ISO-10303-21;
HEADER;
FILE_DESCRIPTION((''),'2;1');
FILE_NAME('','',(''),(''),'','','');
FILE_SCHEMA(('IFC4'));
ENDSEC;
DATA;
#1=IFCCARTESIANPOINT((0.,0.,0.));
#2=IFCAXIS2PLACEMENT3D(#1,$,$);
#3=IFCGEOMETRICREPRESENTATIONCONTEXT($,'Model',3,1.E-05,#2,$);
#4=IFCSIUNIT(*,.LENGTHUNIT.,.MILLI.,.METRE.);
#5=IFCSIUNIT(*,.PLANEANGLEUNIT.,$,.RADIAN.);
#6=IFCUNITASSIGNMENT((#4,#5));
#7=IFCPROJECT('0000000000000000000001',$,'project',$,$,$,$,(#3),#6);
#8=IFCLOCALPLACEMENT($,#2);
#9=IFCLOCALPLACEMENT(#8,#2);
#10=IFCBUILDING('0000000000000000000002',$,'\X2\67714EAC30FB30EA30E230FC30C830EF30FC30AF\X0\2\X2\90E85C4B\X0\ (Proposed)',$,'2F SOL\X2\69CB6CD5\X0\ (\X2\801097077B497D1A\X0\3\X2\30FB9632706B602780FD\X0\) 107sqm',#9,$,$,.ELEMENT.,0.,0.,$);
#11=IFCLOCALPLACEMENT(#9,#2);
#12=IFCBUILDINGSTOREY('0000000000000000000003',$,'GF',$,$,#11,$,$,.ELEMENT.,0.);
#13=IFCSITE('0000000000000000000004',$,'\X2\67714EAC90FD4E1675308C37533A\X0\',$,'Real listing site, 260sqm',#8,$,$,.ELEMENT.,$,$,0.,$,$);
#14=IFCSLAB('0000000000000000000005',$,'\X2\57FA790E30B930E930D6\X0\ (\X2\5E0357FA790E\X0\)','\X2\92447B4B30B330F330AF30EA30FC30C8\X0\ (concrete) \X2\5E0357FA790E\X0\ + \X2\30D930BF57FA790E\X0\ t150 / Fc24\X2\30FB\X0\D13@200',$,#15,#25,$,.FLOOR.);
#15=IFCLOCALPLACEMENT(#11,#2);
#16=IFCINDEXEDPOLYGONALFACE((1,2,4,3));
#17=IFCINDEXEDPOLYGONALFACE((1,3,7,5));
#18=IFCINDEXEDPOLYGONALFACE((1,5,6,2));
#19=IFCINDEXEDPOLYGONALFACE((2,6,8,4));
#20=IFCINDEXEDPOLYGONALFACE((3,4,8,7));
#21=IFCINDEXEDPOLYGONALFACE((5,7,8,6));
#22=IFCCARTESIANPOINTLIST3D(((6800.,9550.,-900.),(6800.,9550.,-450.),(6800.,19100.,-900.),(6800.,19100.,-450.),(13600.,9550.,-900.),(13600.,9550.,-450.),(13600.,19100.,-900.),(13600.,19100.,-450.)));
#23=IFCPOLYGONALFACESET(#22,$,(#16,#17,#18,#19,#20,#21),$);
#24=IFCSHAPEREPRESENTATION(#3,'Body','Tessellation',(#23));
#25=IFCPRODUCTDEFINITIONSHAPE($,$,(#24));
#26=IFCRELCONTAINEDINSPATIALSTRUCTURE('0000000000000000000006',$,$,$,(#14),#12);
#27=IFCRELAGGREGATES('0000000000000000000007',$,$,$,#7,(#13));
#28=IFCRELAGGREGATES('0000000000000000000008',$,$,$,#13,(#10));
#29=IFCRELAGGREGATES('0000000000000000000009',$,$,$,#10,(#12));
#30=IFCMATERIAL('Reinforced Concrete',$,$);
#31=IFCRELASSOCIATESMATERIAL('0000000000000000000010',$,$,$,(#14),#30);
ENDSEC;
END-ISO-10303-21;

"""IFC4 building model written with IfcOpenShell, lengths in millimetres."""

from ifc_helpers import new_model, si_unit, frame, frame_2d, origin, place, context, project, spatial, rectangle, extrude, material, element, save


model = new_model("IFC4")

# Units and contexts
model_context = context("Model", 3, precision=1e-05, world=origin())
ifc_project = project(units=[si_unit("LENGTHUNIT", "METRE", prefix="MILLI"), si_unit("PLANEANGLEUNIT", "RADIAN")], contexts=[model_context])

# Site, building, storey
site_placement = place(None, origin())
site = spatial("IfcSite", under=ifc_project, at=site_placement, Name="東京都世田谷区", ObjectType="Real listing site, 260sqm", CompositionType="ELEMENT", RefElevation=0.0)
building_placement = place(site_placement, origin())
building = spatial("IfcBuilding", under=site, at=building_placement, Name="東京・リモートワーク2部屋 (Proposed)", ObjectType="2F SOL構法 (耐震等級3・防火性能) 107sqm", CompositionType="ELEMENT", ElevationOfRefHeight=0.0, ElevationOfTerrain=0.0)
storey_placement = place(building_placement, origin())
storey = spatial("IfcBuildingStorey", under=building, at=storey_placement, Name="GF", CompositionType="ELEMENT", Elevation=0.0)

# Slab
ifc_material_1 = material(Name="Reinforced Concrete")
slab_1_placement = place(storey_placement, frame((3400.0, 4775.0, -450.0)))
element("IfcSlab", 1, at=slab_1_placement, inside=storey, material=ifc_material_1, Name="基礎スラブ (布基礎)", Description="鉄筋コンクリート (concrete) 布基礎 + ベタ基礎 t150 / Fc24・D13@200", PredefinedType="FLOOR", context=model_context, shape_type="SweptSolid", body=[
    extrude(rectangle(XDim=6800.0, YDim=9550.0, at=frame_2d((3400.0, 4775.0))), frame((3400.0, 4775.0, -450.0)), (0.0, 0.0, 1.0), 450.0),
])

save(model, "model.ifc")
